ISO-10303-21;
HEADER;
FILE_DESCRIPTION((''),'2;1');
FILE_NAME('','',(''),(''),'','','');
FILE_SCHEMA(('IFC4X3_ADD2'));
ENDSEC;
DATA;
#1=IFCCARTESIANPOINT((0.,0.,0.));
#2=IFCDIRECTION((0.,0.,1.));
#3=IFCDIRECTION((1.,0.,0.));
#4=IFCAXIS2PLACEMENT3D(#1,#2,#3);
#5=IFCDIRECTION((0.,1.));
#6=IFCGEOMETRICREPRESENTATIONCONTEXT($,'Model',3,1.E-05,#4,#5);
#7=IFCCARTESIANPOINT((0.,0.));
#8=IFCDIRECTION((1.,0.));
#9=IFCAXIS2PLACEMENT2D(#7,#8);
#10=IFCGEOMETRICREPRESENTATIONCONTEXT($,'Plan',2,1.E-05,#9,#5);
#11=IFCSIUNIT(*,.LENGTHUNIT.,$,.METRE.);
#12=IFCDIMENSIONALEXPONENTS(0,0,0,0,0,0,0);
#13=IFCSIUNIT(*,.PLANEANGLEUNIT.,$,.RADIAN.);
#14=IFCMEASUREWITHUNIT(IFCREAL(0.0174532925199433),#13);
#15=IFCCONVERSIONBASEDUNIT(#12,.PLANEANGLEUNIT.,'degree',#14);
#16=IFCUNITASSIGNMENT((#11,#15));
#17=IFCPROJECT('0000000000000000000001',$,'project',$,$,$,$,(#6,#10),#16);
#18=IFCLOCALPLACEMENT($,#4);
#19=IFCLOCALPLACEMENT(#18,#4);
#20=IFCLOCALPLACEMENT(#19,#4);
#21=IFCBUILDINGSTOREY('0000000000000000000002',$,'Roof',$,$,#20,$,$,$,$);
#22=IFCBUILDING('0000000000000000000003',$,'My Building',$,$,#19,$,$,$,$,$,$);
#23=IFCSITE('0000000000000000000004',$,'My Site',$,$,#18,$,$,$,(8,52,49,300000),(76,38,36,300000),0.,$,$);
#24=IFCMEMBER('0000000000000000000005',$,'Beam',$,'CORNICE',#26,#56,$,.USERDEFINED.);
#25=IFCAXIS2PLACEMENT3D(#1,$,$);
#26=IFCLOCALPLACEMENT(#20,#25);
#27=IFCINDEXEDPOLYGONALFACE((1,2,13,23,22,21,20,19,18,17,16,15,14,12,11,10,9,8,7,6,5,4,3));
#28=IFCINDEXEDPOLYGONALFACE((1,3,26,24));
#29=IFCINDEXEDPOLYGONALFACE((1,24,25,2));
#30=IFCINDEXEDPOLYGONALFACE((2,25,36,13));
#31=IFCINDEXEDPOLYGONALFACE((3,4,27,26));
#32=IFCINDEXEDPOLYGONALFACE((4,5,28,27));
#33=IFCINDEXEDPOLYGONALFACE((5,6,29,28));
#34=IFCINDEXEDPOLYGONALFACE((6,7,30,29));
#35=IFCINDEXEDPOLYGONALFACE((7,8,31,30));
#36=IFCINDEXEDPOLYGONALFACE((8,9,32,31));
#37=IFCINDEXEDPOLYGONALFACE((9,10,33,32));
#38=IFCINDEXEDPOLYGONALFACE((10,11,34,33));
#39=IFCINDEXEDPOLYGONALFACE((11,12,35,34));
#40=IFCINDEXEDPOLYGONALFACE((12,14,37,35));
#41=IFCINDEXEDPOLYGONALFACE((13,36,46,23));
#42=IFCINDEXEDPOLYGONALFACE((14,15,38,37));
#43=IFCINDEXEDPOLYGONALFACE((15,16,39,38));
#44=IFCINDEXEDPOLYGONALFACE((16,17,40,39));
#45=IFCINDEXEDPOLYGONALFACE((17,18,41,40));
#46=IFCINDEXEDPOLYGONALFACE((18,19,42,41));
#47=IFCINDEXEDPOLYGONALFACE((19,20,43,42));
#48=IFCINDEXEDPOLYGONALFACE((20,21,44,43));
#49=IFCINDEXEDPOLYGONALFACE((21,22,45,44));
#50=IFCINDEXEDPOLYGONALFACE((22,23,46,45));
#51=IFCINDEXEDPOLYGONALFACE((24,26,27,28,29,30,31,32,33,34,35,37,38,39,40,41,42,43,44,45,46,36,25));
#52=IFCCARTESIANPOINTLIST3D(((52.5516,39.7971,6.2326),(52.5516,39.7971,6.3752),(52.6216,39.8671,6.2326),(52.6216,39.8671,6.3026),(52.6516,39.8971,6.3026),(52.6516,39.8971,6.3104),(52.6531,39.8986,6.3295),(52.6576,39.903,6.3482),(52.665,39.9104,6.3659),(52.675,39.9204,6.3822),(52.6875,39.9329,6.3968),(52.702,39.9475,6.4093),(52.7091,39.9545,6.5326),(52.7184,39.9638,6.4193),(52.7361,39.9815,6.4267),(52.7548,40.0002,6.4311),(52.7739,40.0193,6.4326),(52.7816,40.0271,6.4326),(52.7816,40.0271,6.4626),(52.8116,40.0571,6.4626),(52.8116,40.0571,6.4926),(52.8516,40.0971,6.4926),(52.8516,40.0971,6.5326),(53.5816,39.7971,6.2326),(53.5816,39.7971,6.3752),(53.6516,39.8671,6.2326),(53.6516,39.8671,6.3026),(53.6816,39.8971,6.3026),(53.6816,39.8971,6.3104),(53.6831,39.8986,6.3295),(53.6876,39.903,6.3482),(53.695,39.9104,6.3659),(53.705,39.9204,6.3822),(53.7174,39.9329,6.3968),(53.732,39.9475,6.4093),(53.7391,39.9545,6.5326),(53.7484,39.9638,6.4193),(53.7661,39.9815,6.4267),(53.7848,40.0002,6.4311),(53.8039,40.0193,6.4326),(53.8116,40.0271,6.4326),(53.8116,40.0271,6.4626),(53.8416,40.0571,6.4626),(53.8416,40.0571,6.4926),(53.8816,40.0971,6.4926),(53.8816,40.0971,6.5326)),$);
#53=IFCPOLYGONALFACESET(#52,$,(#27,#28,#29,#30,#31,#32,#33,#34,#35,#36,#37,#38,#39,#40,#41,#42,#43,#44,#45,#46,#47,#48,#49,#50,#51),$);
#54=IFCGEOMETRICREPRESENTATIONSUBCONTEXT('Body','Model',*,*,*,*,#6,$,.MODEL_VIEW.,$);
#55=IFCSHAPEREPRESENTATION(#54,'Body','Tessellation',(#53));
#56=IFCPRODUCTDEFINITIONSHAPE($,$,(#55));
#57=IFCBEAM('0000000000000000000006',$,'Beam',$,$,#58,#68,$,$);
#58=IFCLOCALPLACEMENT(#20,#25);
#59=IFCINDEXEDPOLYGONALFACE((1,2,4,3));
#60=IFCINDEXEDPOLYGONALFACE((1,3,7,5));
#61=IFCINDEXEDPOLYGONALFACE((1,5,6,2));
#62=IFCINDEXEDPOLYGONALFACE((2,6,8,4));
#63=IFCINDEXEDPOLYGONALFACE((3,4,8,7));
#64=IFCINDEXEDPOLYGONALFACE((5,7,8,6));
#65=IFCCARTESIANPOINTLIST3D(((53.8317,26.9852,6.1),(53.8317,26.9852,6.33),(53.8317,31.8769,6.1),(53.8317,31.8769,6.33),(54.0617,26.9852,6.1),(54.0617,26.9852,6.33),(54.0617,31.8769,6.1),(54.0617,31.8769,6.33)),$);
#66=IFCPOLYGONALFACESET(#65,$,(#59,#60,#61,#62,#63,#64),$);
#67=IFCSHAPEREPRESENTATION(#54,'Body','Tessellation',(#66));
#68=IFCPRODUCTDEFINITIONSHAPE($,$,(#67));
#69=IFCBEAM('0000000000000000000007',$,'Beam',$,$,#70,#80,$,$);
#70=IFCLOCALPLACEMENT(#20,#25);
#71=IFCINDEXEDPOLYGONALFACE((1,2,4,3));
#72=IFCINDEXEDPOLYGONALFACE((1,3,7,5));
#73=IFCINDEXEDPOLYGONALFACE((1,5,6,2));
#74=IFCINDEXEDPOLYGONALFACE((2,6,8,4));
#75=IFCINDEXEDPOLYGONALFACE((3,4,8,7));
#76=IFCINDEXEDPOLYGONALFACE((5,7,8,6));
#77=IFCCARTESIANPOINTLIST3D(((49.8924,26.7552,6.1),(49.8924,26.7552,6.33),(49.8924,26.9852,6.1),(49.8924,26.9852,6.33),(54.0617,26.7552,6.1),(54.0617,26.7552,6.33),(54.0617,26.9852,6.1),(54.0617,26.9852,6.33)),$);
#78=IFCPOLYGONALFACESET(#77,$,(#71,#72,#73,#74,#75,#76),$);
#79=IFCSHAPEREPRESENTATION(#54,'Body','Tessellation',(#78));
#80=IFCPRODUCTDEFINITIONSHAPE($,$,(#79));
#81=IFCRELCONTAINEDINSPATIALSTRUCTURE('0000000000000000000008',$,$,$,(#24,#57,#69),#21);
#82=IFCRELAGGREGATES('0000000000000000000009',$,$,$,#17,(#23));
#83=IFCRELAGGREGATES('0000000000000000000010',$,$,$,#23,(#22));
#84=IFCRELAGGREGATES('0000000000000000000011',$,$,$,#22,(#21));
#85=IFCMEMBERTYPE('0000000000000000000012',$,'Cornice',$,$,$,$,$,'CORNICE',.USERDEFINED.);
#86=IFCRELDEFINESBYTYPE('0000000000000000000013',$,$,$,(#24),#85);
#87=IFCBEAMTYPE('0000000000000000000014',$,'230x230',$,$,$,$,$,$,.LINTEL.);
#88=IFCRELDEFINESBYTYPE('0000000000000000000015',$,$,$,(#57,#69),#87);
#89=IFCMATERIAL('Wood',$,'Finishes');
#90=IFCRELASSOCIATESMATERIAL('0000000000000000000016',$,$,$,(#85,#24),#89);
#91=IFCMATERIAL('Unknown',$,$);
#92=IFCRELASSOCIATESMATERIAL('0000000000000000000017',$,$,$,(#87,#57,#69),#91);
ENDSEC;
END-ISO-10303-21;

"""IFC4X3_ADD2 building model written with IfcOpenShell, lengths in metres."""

from ifc_helpers import new_model, entity, si_unit, converted_unit, direction, frame, origin_with_axes, origin_2d_with_axis, place, context, subcontext, project, spatial, indexed_curve, rectangle, outline, extrude, clip, halfspace, material, material_profile, profile_set, profile_usage, type_object, element, save


model = new_model("IFC4X3_ADD2")

# Units and contexts
model_context = context("Model", 3, precision=1e-05, world=origin_with_axes(), true_north=direction((0.0, 1.0)))
plan_context = context("Plan", 2, precision=1e-05, world=origin_2d_with_axis(), true_north=direction((0.0, 1.0)))
body_context = subcontext(model_context, "Body", "Model", "MODEL_VIEW")
ifc_project = project(units=[si_unit("LENGTHUNIT", "METRE"), converted_unit("PLANEANGLEUNIT", "degree", entity("IfcReal", 0.0174532925199433), si_unit("PLANEANGLEUNIT", "RADIAN"), dimensions=[0, 0, 0, 0, 0, 0, 0])], contexts=[model_context, plan_context])

# Site, building, storey
site_placement = place(None, origin_with_axes())
site = spatial("IfcSite", under=ifc_project, at=site_placement, Name="My Site", RefLatitude=(8, 52, 49, 300000), RefLongitude=(76, 38, 36, 300000), RefElevation=0.0)
building_placement = place(site_placement, origin_with_axes())
building = spatial("IfcBuilding", under=site, at=building_placement, Name="My Building")
storey_placement = place(building_placement, origin_with_axes())
storey = spatial("IfcBuildingStorey", under=building, at=storey_placement, Name="Roof")

# Member
ifc_material_1 = material(Name="Wood", Category="Finishes")
ifc_material_profile_1 = material_profile(ifc_material_1, outline(indexed_curve([(-0.26, 0.26), (-0.3, 0.26), (-0.3, 0.3), (-0.1574, 0.3), (0.0, 0.1426), (0.0, 0.0), (-0.07, 0.0), (-0.07, 0.07), (-0.1, 0.07), (-0.1, 0.0777), (-0.1015, 0.0969), (-0.106, 0.1155), (-0.1133, 0.1332), (-0.1233, 0.1496), (-0.1358, 0.1642), (-0.1504, 0.1767), (-0.1668, 0.1867), (-0.1845, 0.194), (-0.2031, 0.1985), (-0.2223, 0.2), (-0.23, 0.2), (-0.23, 0.23), (-0.26, 0.23), (-0.26, 0.26)])))
ifc_profile_set_1 = profile_set([ifc_material_profile_1])
member_type = type_object("IfcMemberType", Name="Cornice", ElementType="CORNICE", PredefinedType="USERDEFINED", material=ifc_profile_set_1)
ifc_profile_usage_1 = profile_usage(ifc_profile_set_1, cardinal=5)
member_1_placement = place(storey_placement, frame((53.8816, 39.7971, 6.2326), z_axis=(-1.0, 0.0, 0.0), x_axis=(0.0, -1.0, 0.0)))
element("IfcMember", 1, at=member_1_placement, inside=storey, type_object=member_type, material=ifc_profile_usage_1, Name="Beam", ObjectType="CORNICE", PredefinedType="USERDEFINED", context=body_context, shape_type="Clipping", body=[
    clip(clip(extrude(outline(indexed_curve([(-0.26, 0.26), (-0.3, 0.26), (-0.3, 0.3), (-0.1574, 0.3), (0.0, 0.1426), (0.0, 0.0), (-0.07, 0.0), (-0.07, 0.07), (-0.1, 0.07), (-0.1, 0.0777), (-0.1015, 0.0969), (-0.106, 0.1155), (-0.1133, 0.1332), (-0.1233, 0.1496), (-0.1358, 0.1642), (-0.1504, 0.1767), (-0.1668, 0.1867), (-0.1845, 0.194), (-0.2031, 0.1985), (-0.2223, 0.2), (-0.23, 0.2), (-0.23, 0.23), (-0.26, 0.23), (-0.26, 0.26)])), origin_with_axes(), (0.0, 0.0, 1.0), 1.33), halfspace(frame((0.0, -6.1726, 1.33), z_axis=(-0.707107, 0.0, 0.707107), x_axis=(0.0, 1.0, 0.0)), False)), halfspace(frame((-0.3, -6.1726, 0.0), z_axis=(0.707107, 0.0, -0.707107), x_axis=(0.0, -1.0, 0.0)), False)),
])

# Beams
ifc_material_2 = material(Name="Unknown")
ifc_material_profile_2 = material_profile(ifc_material_2, rectangle(XDim=0.23, YDim=0.23))
ifc_profile_set_2 = profile_set([ifc_material_profile_2])
ifc_profile_usage_2 = profile_usage(ifc_profile_set_2, cardinal=5)
beam_type = type_object("IfcBeamType", Name="230x230", PredefinedType="LINTEL", material=ifc_profile_set_2)
beam_1_placement = place(storey_placement, frame((53.9467, 26.9852, 6.215), z_axis=(0.0, 1.0, 0.0), x_axis=(-1.0, 0.0, 0.0)))
element("IfcBeam", 2, at=beam_1_placement, inside=storey, type_object=beam_type, material=ifc_profile_usage_2, Name="Beam", context=body_context, shape_type="SweptSolid", body=[
    extrude(rectangle(XDim=0.23, YDim=0.23), origin_with_axes(), (0.0, 0.0, 1.0), 4.8917),
])
ifc_profile_usage_3 = profile_usage(ifc_profile_set_2, cardinal=5)
beam_2_placement = place(storey_placement, frame((49.8924, 26.8702, 6.215), z_axis=(1.0, 0.0, 0.0), x_axis=(0.0, 1.0, 0.0)))
element("IfcBeam", 3, at=beam_2_placement, inside=storey, type_object=beam_type, material=ifc_profile_usage_3, Name="Beam", context=body_context, shape_type="SweptSolid", body=[
    extrude(rectangle(XDim=0.23, YDim=0.23), origin_with_axes(), (0.0, 0.0, 1.0), 4.1693),
])

save(model, "model.ifc")
